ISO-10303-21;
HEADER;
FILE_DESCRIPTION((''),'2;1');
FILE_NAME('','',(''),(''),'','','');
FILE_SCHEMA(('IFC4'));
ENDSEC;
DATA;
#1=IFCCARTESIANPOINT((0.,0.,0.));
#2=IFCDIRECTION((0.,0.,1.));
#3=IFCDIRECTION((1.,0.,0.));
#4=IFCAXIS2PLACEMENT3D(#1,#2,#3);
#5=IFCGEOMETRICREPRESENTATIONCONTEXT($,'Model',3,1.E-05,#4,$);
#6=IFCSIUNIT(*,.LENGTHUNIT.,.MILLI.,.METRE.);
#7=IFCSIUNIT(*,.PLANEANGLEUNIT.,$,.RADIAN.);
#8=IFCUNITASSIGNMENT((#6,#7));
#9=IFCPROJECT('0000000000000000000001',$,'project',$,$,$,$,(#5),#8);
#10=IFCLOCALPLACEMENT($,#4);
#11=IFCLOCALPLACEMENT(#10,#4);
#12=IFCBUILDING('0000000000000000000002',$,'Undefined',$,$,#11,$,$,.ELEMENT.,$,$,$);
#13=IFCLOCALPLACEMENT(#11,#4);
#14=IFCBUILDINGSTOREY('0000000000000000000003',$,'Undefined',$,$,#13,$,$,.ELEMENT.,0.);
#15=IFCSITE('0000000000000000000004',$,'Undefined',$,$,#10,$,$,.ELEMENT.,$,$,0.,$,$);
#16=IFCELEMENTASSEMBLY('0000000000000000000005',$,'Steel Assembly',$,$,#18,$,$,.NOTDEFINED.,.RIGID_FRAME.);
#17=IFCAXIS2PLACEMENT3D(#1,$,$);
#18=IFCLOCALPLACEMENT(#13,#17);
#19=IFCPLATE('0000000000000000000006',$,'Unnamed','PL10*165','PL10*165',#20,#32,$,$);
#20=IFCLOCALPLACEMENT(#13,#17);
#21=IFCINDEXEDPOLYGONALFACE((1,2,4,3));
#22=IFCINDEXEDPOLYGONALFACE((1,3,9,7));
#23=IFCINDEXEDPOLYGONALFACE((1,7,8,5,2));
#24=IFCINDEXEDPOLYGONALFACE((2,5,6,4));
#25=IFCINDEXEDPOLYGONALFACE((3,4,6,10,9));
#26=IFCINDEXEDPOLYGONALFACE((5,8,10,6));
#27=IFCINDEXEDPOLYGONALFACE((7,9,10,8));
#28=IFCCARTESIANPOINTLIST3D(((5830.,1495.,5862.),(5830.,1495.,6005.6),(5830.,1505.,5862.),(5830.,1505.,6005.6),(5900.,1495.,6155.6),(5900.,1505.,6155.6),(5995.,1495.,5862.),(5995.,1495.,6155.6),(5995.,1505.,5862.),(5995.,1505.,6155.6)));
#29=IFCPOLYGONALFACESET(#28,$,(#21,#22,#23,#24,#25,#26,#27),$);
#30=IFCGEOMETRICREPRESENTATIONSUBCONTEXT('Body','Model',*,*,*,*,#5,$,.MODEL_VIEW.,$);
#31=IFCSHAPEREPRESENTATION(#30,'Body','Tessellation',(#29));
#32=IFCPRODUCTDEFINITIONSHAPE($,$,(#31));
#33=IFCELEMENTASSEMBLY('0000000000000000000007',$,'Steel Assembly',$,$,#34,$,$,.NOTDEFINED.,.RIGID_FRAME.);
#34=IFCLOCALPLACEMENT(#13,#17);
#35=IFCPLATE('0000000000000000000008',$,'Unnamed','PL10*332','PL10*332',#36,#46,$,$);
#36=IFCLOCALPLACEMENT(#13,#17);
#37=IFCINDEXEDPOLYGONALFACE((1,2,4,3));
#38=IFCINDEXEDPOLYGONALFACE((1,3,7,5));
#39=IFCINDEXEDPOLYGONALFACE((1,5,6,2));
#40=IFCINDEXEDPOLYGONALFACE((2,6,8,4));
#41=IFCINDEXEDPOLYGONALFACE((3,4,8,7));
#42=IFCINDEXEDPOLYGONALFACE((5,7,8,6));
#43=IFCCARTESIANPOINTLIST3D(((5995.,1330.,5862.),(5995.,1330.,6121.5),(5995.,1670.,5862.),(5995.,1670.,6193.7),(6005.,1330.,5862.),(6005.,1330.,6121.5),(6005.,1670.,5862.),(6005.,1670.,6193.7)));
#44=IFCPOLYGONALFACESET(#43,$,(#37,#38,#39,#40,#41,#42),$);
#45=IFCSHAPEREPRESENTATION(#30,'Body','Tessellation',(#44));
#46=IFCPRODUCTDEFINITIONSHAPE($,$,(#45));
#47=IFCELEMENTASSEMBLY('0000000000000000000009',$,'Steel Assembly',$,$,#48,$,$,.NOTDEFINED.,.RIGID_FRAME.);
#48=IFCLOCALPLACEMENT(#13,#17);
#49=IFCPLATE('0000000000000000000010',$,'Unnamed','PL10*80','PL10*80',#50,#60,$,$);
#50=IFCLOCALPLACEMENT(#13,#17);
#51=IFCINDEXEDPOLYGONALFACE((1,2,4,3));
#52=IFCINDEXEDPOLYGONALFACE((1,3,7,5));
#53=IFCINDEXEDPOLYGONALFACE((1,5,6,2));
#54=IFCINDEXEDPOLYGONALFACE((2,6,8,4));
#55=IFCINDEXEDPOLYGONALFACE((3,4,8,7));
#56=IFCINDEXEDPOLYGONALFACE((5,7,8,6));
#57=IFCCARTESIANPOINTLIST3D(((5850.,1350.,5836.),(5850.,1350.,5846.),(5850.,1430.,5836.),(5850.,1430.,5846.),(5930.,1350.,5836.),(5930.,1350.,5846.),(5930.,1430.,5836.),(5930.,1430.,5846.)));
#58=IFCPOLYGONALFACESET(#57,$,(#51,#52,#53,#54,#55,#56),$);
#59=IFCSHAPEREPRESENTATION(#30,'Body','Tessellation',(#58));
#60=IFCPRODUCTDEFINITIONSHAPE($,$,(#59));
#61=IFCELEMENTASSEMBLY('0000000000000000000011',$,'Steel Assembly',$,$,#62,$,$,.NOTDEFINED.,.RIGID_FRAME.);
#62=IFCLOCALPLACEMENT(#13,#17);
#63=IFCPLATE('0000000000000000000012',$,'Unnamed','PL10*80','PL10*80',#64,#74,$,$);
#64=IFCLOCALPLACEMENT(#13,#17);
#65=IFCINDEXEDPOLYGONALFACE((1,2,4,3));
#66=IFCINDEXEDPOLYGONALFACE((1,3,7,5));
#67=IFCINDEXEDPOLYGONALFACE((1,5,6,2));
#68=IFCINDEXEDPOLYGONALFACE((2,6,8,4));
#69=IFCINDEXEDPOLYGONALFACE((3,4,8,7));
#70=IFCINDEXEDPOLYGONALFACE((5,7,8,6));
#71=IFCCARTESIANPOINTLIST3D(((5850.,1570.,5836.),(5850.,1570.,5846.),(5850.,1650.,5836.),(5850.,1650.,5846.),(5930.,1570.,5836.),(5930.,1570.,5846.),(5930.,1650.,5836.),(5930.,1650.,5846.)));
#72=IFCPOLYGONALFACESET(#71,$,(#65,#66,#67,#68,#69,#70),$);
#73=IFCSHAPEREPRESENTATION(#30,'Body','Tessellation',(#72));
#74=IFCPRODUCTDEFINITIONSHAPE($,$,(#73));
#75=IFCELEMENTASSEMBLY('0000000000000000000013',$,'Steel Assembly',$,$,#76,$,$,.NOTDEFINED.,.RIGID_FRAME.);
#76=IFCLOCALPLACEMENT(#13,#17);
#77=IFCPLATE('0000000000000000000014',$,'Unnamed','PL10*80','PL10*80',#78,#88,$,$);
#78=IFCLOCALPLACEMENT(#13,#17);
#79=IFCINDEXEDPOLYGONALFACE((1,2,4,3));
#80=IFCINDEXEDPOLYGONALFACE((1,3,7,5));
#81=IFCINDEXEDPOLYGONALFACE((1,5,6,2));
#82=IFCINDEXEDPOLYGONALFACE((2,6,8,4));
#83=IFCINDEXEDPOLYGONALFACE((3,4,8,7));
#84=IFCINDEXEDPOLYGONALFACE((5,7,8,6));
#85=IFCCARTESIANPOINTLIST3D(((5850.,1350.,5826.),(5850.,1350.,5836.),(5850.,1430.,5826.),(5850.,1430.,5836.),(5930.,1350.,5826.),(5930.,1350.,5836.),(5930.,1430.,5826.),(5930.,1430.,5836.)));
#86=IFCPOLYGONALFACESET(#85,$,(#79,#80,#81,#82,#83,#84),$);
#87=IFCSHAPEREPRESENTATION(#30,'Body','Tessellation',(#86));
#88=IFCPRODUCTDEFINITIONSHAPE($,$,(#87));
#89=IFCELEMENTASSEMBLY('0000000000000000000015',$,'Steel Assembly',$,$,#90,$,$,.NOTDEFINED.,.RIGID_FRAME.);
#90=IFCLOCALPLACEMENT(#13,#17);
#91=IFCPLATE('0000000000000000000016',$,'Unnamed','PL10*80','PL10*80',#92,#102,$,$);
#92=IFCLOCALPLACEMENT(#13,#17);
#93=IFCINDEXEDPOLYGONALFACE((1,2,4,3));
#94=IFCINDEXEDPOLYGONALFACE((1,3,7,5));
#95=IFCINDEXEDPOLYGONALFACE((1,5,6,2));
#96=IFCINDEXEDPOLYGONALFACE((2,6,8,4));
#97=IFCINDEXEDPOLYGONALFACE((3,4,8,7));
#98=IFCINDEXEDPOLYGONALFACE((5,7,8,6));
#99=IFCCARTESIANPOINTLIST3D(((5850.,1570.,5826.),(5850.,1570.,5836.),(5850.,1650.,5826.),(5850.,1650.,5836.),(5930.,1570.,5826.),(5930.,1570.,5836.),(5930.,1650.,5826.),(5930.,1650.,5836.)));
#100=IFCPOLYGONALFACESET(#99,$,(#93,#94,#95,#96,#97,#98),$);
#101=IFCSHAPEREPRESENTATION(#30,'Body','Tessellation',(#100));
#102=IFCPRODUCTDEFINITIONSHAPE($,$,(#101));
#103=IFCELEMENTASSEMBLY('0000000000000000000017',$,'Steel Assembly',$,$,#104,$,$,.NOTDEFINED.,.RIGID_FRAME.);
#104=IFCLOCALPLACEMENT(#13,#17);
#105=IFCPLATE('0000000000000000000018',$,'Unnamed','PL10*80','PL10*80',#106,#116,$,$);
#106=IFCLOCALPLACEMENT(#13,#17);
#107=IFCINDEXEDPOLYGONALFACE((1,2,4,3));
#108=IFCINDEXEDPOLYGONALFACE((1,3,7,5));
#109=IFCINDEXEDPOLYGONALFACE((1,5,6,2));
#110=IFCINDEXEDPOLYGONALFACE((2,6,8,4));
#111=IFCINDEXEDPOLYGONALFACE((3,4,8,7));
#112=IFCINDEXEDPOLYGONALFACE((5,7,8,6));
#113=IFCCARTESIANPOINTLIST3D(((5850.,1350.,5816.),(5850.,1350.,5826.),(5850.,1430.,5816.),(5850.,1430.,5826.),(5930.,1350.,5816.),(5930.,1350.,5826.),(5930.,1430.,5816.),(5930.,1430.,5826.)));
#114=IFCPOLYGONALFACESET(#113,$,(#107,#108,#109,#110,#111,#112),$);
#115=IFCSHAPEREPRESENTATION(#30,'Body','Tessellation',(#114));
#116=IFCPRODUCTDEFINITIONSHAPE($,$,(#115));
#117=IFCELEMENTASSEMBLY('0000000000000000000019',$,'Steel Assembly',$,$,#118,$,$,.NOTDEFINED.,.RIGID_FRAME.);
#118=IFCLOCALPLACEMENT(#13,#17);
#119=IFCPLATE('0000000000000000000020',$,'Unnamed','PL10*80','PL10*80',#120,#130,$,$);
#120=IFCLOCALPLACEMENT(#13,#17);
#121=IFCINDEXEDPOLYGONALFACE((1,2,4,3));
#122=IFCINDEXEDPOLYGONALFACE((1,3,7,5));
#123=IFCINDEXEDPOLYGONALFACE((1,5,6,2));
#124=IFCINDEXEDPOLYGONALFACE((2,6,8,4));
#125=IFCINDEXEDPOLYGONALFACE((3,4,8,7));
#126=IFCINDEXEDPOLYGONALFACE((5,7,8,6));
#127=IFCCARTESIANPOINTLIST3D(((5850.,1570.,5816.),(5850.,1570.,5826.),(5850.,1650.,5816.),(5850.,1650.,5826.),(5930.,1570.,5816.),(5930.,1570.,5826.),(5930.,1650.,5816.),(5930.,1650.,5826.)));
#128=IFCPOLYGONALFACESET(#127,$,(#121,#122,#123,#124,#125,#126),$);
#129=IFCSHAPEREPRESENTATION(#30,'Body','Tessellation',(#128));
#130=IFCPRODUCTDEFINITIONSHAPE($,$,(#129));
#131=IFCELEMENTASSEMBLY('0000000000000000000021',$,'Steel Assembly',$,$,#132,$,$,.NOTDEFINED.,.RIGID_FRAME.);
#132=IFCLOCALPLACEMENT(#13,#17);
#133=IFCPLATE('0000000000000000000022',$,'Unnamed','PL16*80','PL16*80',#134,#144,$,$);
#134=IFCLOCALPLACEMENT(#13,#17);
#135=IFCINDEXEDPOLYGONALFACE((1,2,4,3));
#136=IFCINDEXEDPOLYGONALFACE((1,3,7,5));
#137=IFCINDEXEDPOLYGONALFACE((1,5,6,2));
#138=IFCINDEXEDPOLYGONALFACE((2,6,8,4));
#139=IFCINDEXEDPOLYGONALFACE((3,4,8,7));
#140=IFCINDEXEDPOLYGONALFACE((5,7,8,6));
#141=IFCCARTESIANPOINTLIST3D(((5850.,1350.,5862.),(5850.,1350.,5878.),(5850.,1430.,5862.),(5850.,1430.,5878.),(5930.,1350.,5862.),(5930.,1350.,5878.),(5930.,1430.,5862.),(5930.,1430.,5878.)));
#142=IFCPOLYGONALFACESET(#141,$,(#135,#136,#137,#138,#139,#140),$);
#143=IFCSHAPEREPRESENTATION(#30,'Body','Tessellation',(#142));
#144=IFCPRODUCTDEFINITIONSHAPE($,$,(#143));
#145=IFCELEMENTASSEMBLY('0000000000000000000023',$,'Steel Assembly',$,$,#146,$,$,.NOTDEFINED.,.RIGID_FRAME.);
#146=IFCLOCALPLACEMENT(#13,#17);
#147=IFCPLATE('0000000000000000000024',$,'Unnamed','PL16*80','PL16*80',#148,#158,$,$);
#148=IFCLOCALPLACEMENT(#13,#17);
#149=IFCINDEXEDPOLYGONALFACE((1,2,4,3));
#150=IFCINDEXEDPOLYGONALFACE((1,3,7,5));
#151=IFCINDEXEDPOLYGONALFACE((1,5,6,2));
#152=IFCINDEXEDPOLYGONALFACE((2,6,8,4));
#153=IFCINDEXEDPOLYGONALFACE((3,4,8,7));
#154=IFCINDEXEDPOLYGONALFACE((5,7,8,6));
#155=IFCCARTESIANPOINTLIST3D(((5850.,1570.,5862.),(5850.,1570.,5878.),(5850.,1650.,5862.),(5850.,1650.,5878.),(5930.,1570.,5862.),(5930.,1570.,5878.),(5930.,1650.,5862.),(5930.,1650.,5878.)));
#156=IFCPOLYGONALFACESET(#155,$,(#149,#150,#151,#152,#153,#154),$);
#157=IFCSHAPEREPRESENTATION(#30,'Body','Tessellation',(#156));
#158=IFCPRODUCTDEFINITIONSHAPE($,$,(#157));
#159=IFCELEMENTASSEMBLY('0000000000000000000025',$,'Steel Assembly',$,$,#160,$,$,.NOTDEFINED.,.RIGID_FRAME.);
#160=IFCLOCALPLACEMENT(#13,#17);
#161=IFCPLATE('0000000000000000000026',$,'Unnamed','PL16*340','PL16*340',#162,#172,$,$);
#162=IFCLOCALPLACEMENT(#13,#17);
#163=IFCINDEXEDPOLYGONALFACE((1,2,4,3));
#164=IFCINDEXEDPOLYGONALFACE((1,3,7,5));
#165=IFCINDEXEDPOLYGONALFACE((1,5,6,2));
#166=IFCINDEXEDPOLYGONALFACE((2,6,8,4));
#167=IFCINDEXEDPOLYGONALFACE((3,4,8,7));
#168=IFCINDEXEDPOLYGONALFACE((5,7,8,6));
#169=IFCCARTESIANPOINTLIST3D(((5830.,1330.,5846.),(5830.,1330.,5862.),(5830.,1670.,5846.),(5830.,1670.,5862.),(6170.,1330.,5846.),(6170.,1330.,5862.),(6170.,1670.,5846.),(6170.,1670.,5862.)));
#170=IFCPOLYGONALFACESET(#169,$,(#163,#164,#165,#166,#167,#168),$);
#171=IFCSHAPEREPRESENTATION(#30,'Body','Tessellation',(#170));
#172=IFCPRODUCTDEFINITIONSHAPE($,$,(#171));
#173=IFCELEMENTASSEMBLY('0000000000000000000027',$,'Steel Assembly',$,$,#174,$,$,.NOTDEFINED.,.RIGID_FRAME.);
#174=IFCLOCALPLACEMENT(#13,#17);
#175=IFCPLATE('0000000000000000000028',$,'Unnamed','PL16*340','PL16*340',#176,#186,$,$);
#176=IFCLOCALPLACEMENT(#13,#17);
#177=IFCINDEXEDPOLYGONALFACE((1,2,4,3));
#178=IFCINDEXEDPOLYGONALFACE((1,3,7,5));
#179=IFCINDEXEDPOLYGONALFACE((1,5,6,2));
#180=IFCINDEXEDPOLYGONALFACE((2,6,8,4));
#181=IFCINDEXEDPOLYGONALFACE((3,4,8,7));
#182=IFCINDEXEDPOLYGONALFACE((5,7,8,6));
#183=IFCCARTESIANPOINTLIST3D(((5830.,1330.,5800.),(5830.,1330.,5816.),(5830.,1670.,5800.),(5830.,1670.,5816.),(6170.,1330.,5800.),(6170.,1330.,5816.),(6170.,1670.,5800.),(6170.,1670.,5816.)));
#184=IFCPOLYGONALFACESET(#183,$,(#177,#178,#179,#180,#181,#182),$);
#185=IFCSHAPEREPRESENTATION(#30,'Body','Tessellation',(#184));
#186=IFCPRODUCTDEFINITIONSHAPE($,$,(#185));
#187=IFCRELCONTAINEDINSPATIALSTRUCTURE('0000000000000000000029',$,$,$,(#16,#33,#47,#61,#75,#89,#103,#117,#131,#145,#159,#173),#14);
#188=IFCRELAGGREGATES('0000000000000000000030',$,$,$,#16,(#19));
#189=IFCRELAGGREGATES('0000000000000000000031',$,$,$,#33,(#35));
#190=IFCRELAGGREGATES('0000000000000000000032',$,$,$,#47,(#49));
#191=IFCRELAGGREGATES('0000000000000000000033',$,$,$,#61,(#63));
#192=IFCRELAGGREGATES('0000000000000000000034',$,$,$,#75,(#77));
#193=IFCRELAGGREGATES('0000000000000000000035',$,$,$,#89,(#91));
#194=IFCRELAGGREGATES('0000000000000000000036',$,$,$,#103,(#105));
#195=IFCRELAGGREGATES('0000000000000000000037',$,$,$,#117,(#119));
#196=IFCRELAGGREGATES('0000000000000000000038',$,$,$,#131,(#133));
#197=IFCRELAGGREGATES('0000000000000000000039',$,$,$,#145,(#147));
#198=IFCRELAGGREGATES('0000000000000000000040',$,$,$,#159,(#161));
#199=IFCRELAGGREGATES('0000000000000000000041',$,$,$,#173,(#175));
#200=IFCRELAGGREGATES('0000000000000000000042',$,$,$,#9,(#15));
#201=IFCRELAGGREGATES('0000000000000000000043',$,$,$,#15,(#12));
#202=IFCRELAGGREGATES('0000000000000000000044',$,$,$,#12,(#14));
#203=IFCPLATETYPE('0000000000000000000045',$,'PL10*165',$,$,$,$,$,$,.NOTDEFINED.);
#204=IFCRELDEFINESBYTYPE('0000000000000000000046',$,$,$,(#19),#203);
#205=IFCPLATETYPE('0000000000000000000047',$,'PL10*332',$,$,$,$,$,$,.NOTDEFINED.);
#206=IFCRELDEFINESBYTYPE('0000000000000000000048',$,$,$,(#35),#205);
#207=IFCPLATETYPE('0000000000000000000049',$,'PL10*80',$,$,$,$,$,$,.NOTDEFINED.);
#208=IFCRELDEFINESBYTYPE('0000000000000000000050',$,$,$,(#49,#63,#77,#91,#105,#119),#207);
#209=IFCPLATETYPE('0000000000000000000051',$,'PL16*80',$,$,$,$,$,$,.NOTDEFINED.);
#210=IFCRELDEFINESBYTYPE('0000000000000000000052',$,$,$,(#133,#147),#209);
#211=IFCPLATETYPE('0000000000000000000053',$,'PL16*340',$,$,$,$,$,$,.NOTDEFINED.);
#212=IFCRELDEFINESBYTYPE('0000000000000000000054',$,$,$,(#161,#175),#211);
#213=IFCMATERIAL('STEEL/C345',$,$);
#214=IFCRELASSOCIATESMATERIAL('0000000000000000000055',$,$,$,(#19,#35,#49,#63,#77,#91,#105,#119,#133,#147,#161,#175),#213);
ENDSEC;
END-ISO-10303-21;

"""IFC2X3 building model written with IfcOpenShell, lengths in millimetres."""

from ifc_helpers import new_model, si_unit, frame, origin_with_axes, place, context, subcontext, project, spatial, polyline, outline, extrude, material, type_object, element, aggregate, save


model = new_model("IFC2X3")

# Units and contexts
model_context = context("Model", 3, precision=1e-05, world=origin_with_axes())
body_context = subcontext(model_context, "Body", "Model", "MODEL_VIEW")
ifc_project = project(units=[si_unit("LENGTHUNIT", "METRE", prefix="MILLI"), si_unit("PLANEANGLEUNIT", "RADIAN")], contexts=[model_context])

# Site, building, storey
site_placement = place(None, origin_with_axes())
site = spatial("IfcSite", under=ifc_project, at=site_placement, Name="Undefined", CompositionType="ELEMENT", RefElevation=0.0)
building_placement = place(site_placement, origin_with_axes())
building = spatial("IfcBuilding", under=site, at=building_placement, Name="Undefined", CompositionType="ELEMENT")
storey_placement = place(building_placement, origin_with_axes())
storey = spatial("IfcBuildingStorey", under=building, at=storey_placement, Name="Undefined", CompositionType="ELEMENT", Elevation=0.0)

# Shared definitions
ifc_material_1 = material(Name="STEEL/C345")

# Element assemblies, plates
assembly_1_placement = place(storey_placement, origin_with_axes())
assembly_1 = element("IfcElementAssembly", 1, at=assembly_1_placement, inside=storey, Name="Steel Assembly", AssemblyPlace="NOTDEFINED", PredefinedType="RIGID_FRAME")
plate_type_1 = type_object("IfcPlateType", Name="PL10*165", PredefinedType="NOTDEFINED")
plate_1_placement = place(assembly_1_placement, frame((5995.0, 1500.0, 5862.0), z_axis=(0.0, 1.0, 0.0), x_axis=(-1.0, 0.0, 0.0)))
plate_1 = element("IfcPlate", 2, at=plate_1_placement, type_object=plate_type_1, material=ifc_material_1, Name="Unnamed", Description="PL10*165", ObjectType="PL10*165", context=body_context, shape_type="SweptSolid", body=[
    extrude(outline(polyline([(0.0, 0.0), (165.0, 0.0), (165.0, 143.6), (95.0, 293.6), (0.0, 293.6), (0.0, 0.0)])), frame((0.0, 0.0, -5.0), z_axis=(0.0, 0.0, 1.0), x_axis=(1.0, 0.0, 0.0)), (0.0, 0.0, 1.0), 10.0),
])
aggregate(assembly_1, [plate_1])
assembly_2_placement = place(storey_placement, origin_with_axes())
assembly_2 = element("IfcElementAssembly", 3, at=assembly_2_placement, inside=storey, Name="Steel Assembly", AssemblyPlace="NOTDEFINED", PredefinedType="RIGID_FRAME")
plate_type_2 = type_object("IfcPlateType", Name="PL10*332", PredefinedType="NOTDEFINED")
plate_2_placement = place(assembly_2_placement, frame((6000.0, 1670.0, 5862.0), z_axis=(-1.0, 0.0, 0.0), x_axis=(0.0, -1.0, 0.0)))
plate_2 = element("IfcPlate", 4, at=plate_2_placement, type_object=plate_type_2, material=ifc_material_1, Name="Unnamed", Description="PL10*332", ObjectType="PL10*332", context=body_context, shape_type="SweptSolid", body=[
    extrude(outline(polyline([(0.0, 0.0), (340.0, 0.0), (340.0, 259.5), (0.0, 331.7), (0.0, 0.0)])), frame((0.0, 0.0, -5.0), z_axis=(0.0, 0.0, 1.0), x_axis=(1.0, 0.0, 0.0)), (0.0, 0.0, 1.0), 10.0),
])
aggregate(assembly_2, [plate_2])
assembly_3_placement = place(storey_placement, origin_with_axes())
assembly_3 = element("IfcElementAssembly", 5, at=assembly_3_placement, inside=storey, Name="Steel Assembly", AssemblyPlace="NOTDEFINED", PredefinedType="RIGID_FRAME")
plate_type_3 = type_object("IfcPlateType", Name="PL10*80", PredefinedType="NOTDEFINED")
plate_3_placement = place(assembly_3_placement, frame((5850.0, 1350.0, 5841.0), z_axis=(0.0, 0.0, -1.0), x_axis=(0.0, 1.0, 0.0)))
plate_3 = element("IfcPlate", 6, at=plate_3_placement, type_object=plate_type_3, material=ifc_material_1, Name="Unnamed", Description="PL10*80", ObjectType="PL10*80", context=body_context, shape_type="SweptSolid", body=[
    extrude(outline(polyline([(0.0, 0.0), (80.0, 0.0), (80.0, 80.0), (0.0, 80.0), (0.0, 0.0)])), frame((0.0, 0.0, -5.0), z_axis=(0.0, 0.0, 1.0), x_axis=(1.0, 0.0, 0.0)), (0.0, 0.0, 1.0), 10.0),
])
aggregate(assembly_3, [plate_3])
assembly_4_placement = place(storey_placement, origin_with_axes())
assembly_4 = element("IfcElementAssembly", 7, at=assembly_4_placement, inside=storey, Name="Steel Assembly", AssemblyPlace="NOTDEFINED", PredefinedType="RIGID_FRAME")
plate_4_placement = place(assembly_4_placement, frame((5850.0, 1650.0, 5841.0), z_axis=(0.0, 0.0, 1.0), x_axis=(0.0, -1.0, 0.0)))
plate_4 = element("IfcPlate", 8, at=plate_4_placement, type_object=plate_type_3, material=ifc_material_1, Name="Unnamed", Description="PL10*80", ObjectType="PL10*80", context=body_context, shape_type="SweptSolid", body=[
    extrude(outline(polyline([(0.0, 0.0), (80.0, 0.0), (80.0, 80.0), (0.0, 80.0), (0.0, 0.0)])), frame((0.0, 0.0, -5.0), z_axis=(0.0, 0.0, 1.0), x_axis=(1.0, 0.0, 0.0)), (0.0, 0.0, 1.0), 10.0),
])
aggregate(assembly_4, [plate_4])
assembly_5_placement = place(storey_placement, origin_with_axes())
assembly_5 = element("IfcElementAssembly", 9, at=assembly_5_placement, inside=storey, Name="Steel Assembly", AssemblyPlace="NOTDEFINED", PredefinedType="RIGID_FRAME")
plate_5_placement = place(assembly_5_placement, frame((5850.0, 1350.0, 5831.0), z_axis=(0.0, 0.0, -1.0), x_axis=(0.0, 1.0, 0.0)))
plate_5 = element("IfcPlate", 10, at=plate_5_placement, type_object=plate_type_3, material=ifc_material_1, Name="Unnamed", Description="PL10*80", ObjectType="PL10*80", context=body_context, shape_type="SweptSolid", body=[
    extrude(outline(polyline([(0.0, 0.0), (80.0, 0.0), (80.0, 80.0), (0.0, 80.0), (0.0, 0.0)])), frame((0.0, 0.0, -5.0), z_axis=(0.0, 0.0, 1.0), x_axis=(1.0, 0.0, 0.0)), (0.0, 0.0, 1.0), 10.0),
])
aggregate(assembly_5, [plate_5])
assembly_6_placement = place(storey_placement, origin_with_axes())
assembly_6 = element("IfcElementAssembly", 11, at=assembly_6_placement, inside=storey, Name="Steel Assembly", AssemblyPlace="NOTDEFINED", PredefinedType="RIGID_FRAME")
plate_6_placement = place(assembly_6_placement, frame((5850.0, 1650.0, 5831.0), z_axis=(0.0, 0.0, 1.0), x_axis=(0.0, -1.0, 0.0)))
plate_6 = element("IfcPlate", 12, at=plate_6_placement, type_object=plate_type_3, material=ifc_material_1, Name="Unnamed", Description="PL10*80", ObjectType="PL10*80", context=body_context, shape_type="SweptSolid", body=[
    extrude(outline(polyline([(0.0, 0.0), (80.0, 0.0), (80.0, 80.0), (0.0, 80.0), (0.0, 0.0)])), frame((0.0, 0.0, -5.0), z_axis=(0.0, 0.0, 1.0), x_axis=(1.0, 0.0, 0.0)), (0.0, 0.0, 1.0), 10.0),
])
aggregate(assembly_6, [plate_6])
assembly_7_placement = place(storey_placement, origin_with_axes())
assembly_7 = element("IfcElementAssembly", 13, at=assembly_7_placement, inside=storey, Name="Steel Assembly", AssemblyPlace="NOTDEFINED", PredefinedType="RIGID_FRAME")
plate_7_placement = place(assembly_7_placement, frame((5850.0, 1350.0, 5821.0), z_axis=(0.0, 0.0, -1.0), x_axis=(0.0, 1.0, 0.0)))
plate_7 = element("IfcPlate", 14, at=plate_7_placement, type_object=plate_type_3, material=ifc_material_1, Name="Unnamed", Description="PL10*80", ObjectType="PL10*80", context=body_context, shape_type="SweptSolid", body=[
    extrude(outline(polyline([(0.0, 0.0), (80.0, 0.0), (80.0, 80.0), (0.0, 80.0), (0.0, 0.0)])), frame((0.0, 0.0, -5.0), z_axis=(0.0, 0.0, 1.0), x_axis=(1.0, 0.0, 0.0)), (0.0, 0.0, 1.0), 10.0),
])
aggregate(assembly_7, [plate_7])
assembly_8_placement = place(storey_placement, origin_with_axes())
assembly_8 = element("IfcElementAssembly", 15, at=assembly_8_placement, inside=storey, Name="Steel Assembly", AssemblyPlace="NOTDEFINED", PredefinedType="RIGID_FRAME")
plate_8_placement = place(assembly_8_placement, frame((5850.0, 1650.0, 5821.0), z_axis=(0.0, 0.0, 1.0), x_axis=(0.0, -1.0, 0.0)))
plate_8 = element("IfcPlate", 16, at=plate_8_placement, type_object=plate_type_3, material=ifc_material_1, Name="Unnamed", Description="PL10*80", ObjectType="PL10*80", context=body_context, shape_type="SweptSolid", body=[
    extrude(outline(polyline([(0.0, 0.0), (80.0, 0.0), (80.0, 80.0), (0.0, 80.0), (0.0, 0.0)])), frame((0.0, 0.0, -5.0), z_axis=(0.0, 0.0, 1.0), x_axis=(1.0, 0.0, 0.0)), (0.0, 0.0, 1.0), 10.0),
])
aggregate(assembly_8, [plate_8])
assembly_9_placement = place(storey_placement, origin_with_axes())
assembly_9 = element("IfcElementAssembly", 17, at=assembly_9_placement, inside=storey, Name="Steel Assembly", AssemblyPlace="NOTDEFINED", PredefinedType="RIGID_FRAME")
plate_type_4 = type_object("IfcPlateType", Name="PL16*80", PredefinedType="NOTDEFINED")
plate_9_placement = place(assembly_9_placement, frame((5850.0, 1350.0, 5870.0), z_axis=(0.0, 0.0, -1.0), x_axis=(0.0, 1.0, 0.0)))
plate_9 = element("IfcPlate", 18, at=plate_9_placement, type_object=plate_type_4, material=ifc_material_1, Name="Unnamed", Description="PL16*80", ObjectType="PL16*80", context=body_context, shape_type="SweptSolid", body=[
    extrude(outline(polyline([(0.0, 0.0), (80.0, 0.0), (80.0, 80.0), (0.0, 80.0), (0.0, 0.0)])), frame((0.0, 0.0, -8.0), z_axis=(0.0, 0.0, 1.0), x_axis=(1.0, 0.0, 0.0)), (0.0, 0.0, 1.0), 16.0),
])
aggregate(assembly_9, [plate_9])
assembly_10_placement = place(storey_placement, origin_with_axes())
assembly_10 = element("IfcElementAssembly", 19, at=assembly_10_placement, inside=storey, Name="Steel Assembly", AssemblyPlace="NOTDEFINED", PredefinedType="RIGID_FRAME")
plate_10_placement = place(assembly_10_placement, frame((5850.0, 1650.0, 5870.0), z_axis=(0.0, 0.0, 1.0), x_axis=(0.0, -1.0, 0.0)))
plate_10 = element("IfcPlate", 20, at=plate_10_placement, type_object=plate_type_4, material=ifc_material_1, Name="Unnamed", Description="PL16*80", ObjectType="PL16*80", context=body_context, shape_type="SweptSolid", body=[
    extrude(outline(polyline([(0.0, 0.0), (80.0, 0.0), (80.0, 80.0), (0.0, 80.0), (0.0, 0.0)])), frame((0.0, 0.0, -8.0), z_axis=(0.0, 0.0, 1.0), x_axis=(1.0, 0.0, 0.0)), (0.0, 0.0, 1.0), 16.0),
])
aggregate(assembly_10, [plate_10])
assembly_11_placement = place(storey_placement, origin_with_axes())
assembly_11 = element("IfcElementAssembly", 21, at=assembly_11_placement, inside=storey, Name="Steel Assembly", AssemblyPlace="NOTDEFINED", PredefinedType="RIGID_FRAME")
plate_type_5 = type_object("IfcPlateType", Name="PL16*340", PredefinedType="NOTDEFINED")
plate_11_placement = place(assembly_11_placement, frame((5830.0, 1670.0, 5854.0), z_axis=(0.0, 0.0, 1.0), x_axis=(0.0, -1.0, 0.0)))
plate_11 = element("IfcPlate", 22, at=plate_11_placement, type_object=plate_type_5, material=ifc_material_1, Name="Unnamed", Description="PL16*340", ObjectType="PL16*340", context=body_context, shape_type="SweptSolid", body=[
    extrude(outline(polyline([(0.0, 0.0), (340.0, 0.0), (340.0, 340.0), (0.0, 340.0), (0.0, 0.0)])), frame((0.0, 0.0, -8.0), z_axis=(0.0, 0.0, 1.0), x_axis=(1.0, 0.0, 0.0)), (0.0, 0.0, 1.0), 16.0),
])
aggregate(assembly_11, [plate_11])
assembly_12_placement = place(storey_placement, origin_with_axes())
assembly_12 = element("IfcElementAssembly", 23, at=assembly_12_placement, inside=storey, Name="Steel Assembly", AssemblyPlace="NOTDEFINED", PredefinedType="RIGID_FRAME")
plate_12_placement = place(assembly_12_placement, frame((5830.0, 1670.0, 5808.0), z_axis=(0.0, 0.0, 1.0), x_axis=(0.0, -1.0, 0.0)))
plate_12 = element("IfcPlate", 24, at=plate_12_placement, type_object=plate_type_5, material=ifc_material_1, Name="Unnamed", Description="PL16*340", ObjectType="PL16*340", context=body_context, shape_type="SweptSolid", body=[
    extrude(outline(polyline([(0.0, 0.0), (340.0, 0.0), (340.0, 340.0), (0.0, 340.0), (0.0, 0.0)])), frame((0.0, 0.0, -8.0), z_axis=(0.0, 0.0, 1.0), x_axis=(1.0, 0.0, 0.0)), (0.0, 0.0, 1.0), 16.0),
])
aggregate(assembly_12, [plate_12])

save(model, "model.ifc")
